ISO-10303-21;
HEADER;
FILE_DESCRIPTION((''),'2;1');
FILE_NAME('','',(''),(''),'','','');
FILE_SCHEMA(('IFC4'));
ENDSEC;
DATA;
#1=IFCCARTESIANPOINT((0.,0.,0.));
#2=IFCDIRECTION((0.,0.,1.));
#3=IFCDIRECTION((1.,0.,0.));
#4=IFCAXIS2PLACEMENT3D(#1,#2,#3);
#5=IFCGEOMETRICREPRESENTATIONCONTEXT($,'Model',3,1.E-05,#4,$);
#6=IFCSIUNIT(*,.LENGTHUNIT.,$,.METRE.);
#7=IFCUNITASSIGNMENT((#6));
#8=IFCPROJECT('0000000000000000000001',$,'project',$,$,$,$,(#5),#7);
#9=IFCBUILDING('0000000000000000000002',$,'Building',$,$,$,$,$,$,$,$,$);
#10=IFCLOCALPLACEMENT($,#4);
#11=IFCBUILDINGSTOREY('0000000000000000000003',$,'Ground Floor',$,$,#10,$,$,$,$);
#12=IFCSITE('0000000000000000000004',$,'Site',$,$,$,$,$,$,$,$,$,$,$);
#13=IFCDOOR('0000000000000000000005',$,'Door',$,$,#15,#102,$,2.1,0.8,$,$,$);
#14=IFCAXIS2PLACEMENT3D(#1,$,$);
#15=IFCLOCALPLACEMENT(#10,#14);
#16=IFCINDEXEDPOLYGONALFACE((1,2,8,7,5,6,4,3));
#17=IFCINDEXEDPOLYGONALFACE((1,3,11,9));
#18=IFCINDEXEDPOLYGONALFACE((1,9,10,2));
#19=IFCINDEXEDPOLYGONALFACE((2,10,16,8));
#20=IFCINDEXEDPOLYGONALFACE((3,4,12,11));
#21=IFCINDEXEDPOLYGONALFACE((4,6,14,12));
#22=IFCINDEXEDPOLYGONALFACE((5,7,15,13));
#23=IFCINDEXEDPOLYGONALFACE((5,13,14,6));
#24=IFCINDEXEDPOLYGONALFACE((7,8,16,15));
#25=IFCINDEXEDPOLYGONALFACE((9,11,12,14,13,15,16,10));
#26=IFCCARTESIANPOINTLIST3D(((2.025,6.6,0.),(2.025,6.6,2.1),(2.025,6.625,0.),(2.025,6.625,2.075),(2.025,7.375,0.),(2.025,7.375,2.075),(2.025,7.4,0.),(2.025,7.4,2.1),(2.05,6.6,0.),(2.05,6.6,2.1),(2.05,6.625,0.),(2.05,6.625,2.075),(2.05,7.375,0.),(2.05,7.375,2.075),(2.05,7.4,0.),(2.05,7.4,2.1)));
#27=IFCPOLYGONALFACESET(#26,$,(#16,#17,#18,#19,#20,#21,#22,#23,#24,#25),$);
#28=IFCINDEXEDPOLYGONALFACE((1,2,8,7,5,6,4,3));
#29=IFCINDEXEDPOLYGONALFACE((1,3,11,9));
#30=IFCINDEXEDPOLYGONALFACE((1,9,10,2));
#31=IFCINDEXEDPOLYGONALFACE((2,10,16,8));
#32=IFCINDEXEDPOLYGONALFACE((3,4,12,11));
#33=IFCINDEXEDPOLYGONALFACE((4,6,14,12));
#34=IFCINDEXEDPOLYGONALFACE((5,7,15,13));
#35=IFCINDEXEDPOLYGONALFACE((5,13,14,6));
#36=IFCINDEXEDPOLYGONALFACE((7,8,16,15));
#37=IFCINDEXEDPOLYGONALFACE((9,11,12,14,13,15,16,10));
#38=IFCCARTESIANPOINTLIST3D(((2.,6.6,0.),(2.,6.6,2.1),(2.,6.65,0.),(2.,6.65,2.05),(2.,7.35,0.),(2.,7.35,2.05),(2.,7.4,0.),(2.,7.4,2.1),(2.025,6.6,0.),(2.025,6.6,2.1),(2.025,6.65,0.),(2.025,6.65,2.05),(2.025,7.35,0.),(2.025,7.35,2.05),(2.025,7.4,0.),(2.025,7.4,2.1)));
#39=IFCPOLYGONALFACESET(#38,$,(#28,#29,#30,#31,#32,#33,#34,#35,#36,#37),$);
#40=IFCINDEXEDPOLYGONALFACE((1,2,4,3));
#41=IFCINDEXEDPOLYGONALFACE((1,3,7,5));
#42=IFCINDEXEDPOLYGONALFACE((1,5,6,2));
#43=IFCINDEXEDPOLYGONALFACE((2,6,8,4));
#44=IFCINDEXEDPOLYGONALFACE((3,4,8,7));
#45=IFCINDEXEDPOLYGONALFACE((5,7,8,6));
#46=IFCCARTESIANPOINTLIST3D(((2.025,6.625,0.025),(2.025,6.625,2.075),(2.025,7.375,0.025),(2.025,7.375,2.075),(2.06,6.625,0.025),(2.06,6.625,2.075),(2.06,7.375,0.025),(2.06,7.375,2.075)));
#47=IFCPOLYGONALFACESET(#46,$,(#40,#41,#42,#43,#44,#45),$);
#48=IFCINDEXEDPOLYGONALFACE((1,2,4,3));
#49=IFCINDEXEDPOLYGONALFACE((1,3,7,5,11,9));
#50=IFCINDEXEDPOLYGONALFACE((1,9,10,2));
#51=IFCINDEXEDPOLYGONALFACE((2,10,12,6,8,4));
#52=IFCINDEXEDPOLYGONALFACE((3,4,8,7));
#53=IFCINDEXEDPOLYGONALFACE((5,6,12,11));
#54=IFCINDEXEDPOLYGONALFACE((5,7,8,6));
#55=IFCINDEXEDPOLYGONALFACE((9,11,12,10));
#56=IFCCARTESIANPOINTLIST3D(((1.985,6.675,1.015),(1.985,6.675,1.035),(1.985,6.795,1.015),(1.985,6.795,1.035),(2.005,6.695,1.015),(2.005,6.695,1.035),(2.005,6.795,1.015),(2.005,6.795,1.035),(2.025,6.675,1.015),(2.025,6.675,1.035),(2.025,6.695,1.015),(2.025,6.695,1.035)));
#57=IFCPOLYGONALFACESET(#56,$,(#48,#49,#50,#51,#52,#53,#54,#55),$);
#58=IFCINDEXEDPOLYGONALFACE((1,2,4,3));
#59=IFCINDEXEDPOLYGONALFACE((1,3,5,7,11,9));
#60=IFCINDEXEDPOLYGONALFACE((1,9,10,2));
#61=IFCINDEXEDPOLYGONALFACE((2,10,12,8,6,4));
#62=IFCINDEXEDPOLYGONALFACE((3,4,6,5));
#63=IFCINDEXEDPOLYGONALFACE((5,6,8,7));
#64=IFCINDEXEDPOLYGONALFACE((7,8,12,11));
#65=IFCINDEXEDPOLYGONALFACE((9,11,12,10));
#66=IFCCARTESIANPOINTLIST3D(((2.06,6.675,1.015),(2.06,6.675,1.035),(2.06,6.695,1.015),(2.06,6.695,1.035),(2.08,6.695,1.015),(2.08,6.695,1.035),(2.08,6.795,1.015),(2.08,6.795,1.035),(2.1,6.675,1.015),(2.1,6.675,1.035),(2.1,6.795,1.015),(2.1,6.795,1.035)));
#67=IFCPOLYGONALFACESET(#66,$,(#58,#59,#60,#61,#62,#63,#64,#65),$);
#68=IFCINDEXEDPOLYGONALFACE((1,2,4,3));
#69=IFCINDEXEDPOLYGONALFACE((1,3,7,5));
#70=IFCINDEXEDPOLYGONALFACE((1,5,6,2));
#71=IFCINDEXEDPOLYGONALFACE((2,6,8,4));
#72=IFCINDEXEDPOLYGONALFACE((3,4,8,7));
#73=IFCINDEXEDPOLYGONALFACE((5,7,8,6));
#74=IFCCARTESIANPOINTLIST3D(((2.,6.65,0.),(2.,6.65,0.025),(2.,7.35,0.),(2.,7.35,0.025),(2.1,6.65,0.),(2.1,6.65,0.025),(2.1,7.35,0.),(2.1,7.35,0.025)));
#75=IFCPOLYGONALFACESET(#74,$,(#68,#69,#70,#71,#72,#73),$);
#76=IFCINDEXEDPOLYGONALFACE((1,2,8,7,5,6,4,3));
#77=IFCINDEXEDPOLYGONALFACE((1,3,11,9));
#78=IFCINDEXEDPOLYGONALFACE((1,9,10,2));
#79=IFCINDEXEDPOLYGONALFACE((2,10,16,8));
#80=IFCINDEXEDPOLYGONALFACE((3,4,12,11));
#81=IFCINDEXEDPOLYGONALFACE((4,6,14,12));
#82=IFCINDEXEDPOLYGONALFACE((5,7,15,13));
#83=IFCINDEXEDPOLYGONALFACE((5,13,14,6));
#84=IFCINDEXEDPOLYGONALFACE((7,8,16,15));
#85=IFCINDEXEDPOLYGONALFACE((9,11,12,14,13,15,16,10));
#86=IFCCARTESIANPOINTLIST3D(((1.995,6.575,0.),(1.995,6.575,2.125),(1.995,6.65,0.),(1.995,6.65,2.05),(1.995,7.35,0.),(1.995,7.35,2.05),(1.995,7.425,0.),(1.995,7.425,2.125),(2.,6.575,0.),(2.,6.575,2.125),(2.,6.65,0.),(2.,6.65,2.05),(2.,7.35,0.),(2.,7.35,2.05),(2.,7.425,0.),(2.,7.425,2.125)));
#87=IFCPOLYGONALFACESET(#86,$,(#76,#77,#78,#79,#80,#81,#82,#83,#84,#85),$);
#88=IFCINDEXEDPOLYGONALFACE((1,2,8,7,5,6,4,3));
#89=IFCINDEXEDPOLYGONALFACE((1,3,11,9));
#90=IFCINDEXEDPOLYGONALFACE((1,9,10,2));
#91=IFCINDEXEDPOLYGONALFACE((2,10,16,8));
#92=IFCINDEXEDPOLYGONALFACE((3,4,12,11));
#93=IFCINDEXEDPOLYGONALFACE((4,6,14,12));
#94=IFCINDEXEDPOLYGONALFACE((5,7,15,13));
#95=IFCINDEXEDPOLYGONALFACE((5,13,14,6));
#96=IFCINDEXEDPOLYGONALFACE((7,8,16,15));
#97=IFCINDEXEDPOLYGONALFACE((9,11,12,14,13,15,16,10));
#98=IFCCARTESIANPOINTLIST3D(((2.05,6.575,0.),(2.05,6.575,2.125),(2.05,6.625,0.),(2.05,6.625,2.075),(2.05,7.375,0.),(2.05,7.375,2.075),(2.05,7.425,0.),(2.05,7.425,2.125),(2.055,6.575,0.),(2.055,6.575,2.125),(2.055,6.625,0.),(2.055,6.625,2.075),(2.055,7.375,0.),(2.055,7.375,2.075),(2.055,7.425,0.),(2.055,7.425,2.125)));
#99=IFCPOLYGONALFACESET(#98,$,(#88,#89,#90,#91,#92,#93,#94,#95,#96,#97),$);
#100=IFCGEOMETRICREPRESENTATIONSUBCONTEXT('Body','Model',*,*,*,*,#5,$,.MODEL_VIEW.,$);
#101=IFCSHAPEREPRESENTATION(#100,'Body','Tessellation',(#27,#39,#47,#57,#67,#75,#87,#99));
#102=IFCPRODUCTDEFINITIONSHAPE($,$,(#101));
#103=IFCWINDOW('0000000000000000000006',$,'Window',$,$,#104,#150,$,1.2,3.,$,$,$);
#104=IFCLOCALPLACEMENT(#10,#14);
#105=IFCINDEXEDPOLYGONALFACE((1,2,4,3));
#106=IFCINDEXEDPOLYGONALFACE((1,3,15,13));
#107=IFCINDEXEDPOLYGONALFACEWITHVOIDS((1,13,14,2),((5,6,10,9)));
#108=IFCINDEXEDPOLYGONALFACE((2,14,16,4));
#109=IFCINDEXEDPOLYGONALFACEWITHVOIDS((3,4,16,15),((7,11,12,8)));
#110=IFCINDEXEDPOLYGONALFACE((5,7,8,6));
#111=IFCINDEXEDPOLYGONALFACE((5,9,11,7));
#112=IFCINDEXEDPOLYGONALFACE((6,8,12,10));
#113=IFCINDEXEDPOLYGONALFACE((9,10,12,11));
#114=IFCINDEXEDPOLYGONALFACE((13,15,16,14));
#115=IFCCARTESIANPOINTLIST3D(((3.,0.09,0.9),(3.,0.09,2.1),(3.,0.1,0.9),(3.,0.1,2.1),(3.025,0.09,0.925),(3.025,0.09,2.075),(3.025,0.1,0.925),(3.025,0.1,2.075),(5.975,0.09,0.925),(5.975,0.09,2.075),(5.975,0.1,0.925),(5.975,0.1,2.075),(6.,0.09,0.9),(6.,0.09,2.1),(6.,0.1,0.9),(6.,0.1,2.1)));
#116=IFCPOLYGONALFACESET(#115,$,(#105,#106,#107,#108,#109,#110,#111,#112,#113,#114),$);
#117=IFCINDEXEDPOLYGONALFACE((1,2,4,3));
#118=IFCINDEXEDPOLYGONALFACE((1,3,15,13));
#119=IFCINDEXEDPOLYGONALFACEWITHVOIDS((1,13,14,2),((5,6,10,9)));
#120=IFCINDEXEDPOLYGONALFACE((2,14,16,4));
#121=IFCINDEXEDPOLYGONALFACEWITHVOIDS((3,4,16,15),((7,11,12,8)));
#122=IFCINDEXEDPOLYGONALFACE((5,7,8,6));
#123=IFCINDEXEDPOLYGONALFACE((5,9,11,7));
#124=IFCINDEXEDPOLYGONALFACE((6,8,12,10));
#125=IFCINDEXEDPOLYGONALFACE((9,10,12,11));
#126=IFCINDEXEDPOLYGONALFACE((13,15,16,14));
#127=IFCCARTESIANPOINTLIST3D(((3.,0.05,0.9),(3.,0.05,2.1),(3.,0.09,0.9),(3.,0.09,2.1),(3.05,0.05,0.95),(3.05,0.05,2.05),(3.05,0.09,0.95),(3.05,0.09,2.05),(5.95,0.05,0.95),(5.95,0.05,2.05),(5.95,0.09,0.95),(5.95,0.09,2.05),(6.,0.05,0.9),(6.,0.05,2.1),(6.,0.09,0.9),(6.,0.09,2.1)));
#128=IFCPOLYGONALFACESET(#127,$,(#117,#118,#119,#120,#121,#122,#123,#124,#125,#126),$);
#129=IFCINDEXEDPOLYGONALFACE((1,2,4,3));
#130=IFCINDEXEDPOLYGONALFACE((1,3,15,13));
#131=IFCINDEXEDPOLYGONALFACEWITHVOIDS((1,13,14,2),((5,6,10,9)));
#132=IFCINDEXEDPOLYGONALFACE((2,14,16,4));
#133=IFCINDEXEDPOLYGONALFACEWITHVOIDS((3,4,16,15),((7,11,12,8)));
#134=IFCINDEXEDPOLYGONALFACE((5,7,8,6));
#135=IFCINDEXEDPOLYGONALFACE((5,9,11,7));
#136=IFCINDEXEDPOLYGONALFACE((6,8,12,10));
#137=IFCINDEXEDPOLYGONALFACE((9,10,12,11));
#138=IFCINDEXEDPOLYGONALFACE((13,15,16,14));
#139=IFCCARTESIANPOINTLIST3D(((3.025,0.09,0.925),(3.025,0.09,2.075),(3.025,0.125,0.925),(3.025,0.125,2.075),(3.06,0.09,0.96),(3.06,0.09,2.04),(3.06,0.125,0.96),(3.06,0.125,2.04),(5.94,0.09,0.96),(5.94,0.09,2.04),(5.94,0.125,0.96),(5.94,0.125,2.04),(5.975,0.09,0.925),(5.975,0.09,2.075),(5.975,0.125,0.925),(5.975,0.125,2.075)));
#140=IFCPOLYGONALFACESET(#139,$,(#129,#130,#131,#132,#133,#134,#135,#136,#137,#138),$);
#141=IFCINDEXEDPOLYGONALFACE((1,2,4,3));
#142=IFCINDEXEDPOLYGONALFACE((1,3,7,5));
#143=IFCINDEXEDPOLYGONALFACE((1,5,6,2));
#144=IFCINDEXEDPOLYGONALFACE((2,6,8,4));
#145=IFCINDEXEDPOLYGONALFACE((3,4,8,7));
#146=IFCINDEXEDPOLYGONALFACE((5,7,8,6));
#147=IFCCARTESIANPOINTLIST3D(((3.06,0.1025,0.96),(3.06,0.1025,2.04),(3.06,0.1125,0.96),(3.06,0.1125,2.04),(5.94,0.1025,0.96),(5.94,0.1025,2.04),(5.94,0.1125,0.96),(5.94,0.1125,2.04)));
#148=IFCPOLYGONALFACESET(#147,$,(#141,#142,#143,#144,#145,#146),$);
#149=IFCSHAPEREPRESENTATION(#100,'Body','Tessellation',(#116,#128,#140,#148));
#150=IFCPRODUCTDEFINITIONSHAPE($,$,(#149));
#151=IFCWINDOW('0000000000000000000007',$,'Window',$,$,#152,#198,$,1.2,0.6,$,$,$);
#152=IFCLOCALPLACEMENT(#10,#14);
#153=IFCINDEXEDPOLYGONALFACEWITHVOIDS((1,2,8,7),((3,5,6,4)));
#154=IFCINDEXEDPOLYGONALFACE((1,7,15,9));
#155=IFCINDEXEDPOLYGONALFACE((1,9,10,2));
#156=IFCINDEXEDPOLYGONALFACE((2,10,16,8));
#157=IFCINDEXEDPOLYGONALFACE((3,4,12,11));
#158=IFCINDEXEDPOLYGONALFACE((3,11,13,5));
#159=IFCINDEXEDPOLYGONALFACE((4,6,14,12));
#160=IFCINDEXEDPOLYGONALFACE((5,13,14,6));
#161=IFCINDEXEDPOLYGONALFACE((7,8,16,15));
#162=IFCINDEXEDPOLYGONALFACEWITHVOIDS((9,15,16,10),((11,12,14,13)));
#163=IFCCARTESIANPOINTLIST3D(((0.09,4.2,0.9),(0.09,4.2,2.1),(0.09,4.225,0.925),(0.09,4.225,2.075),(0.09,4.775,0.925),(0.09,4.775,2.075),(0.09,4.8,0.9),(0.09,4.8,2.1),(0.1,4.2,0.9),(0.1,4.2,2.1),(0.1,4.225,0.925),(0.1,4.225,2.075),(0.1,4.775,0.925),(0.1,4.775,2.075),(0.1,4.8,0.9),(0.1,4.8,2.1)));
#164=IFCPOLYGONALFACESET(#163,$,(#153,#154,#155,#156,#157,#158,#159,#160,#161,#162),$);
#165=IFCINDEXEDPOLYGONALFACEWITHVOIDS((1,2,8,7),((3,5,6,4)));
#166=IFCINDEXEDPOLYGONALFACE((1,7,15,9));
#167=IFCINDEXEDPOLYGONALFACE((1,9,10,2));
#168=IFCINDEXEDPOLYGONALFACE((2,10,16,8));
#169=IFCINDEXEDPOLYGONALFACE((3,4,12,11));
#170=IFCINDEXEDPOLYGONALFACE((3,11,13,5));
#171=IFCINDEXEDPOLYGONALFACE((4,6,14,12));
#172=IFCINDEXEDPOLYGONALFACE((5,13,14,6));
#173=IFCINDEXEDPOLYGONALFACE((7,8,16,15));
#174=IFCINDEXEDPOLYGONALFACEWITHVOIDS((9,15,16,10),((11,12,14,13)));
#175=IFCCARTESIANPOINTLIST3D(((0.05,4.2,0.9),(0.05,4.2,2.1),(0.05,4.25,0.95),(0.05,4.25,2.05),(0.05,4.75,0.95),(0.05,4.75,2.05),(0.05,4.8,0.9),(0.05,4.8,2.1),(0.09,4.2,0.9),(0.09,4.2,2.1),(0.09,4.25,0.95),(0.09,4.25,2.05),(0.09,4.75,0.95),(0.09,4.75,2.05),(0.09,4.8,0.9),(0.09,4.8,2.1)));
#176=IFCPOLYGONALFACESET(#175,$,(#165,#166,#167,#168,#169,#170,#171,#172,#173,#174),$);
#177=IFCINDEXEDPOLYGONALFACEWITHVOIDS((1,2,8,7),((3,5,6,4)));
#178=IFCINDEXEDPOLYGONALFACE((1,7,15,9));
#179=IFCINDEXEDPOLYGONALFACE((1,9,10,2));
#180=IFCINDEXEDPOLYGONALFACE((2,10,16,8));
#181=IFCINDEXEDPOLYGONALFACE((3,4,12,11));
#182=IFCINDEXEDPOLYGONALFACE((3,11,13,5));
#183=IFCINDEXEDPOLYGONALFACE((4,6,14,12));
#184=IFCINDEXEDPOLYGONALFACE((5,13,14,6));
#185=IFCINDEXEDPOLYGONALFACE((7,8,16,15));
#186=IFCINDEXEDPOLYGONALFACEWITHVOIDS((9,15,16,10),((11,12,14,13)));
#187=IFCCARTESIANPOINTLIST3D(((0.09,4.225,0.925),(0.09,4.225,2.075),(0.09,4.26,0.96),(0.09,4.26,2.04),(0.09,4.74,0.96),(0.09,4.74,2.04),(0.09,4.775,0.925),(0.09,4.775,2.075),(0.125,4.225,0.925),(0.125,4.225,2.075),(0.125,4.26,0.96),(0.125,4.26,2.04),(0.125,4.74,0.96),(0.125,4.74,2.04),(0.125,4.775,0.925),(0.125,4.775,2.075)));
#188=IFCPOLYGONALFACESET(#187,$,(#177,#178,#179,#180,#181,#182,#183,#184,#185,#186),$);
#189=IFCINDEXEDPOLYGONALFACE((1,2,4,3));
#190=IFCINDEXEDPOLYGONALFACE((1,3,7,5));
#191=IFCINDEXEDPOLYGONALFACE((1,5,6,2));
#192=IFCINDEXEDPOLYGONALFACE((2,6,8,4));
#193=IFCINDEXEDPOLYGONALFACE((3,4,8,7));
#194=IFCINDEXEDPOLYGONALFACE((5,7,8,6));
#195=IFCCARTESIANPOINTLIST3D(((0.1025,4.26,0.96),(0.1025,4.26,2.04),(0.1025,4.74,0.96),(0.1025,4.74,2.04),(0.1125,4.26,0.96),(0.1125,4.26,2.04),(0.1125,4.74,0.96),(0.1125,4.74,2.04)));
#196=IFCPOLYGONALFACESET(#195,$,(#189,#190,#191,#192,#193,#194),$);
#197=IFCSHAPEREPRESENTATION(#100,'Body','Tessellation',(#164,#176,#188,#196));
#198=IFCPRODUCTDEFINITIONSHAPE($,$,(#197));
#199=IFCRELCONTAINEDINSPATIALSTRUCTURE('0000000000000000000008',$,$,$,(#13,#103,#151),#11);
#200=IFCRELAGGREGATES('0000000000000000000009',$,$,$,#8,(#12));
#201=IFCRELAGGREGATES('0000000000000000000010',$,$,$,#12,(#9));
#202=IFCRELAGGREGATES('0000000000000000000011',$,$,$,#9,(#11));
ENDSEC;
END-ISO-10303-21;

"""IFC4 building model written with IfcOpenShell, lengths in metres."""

from ifc_helpers import new_model, si_unit, frame, origin_with_axes, place, context, subcontext, project, spatial, line, indexed_curve, outline, extrude, element, save


model = new_model("IFC4")

# Units and contexts
model_context = context("Model", 3, precision=1e-05, world=origin_with_axes())
body_context = subcontext(model_context, "Body", "Model", "MODEL_VIEW")
ifc_project = project(units=[si_unit("LENGTHUNIT", "METRE")], contexts=[model_context])

# Site, building, storey
site = spatial("IfcSite", under=ifc_project, Name="Site")
building = spatial("IfcBuilding", under=site, Name="Building")
storey_placement = place(None, origin_with_axes())
storey = spatial("IfcBuildingStorey", under=building, at=storey_placement, Name="Ground Floor")

# Door
door_1_placement = place(storey_placement, frame((2.0, 7.4, 0.0), z_axis=(0.0, 0.0, 1.0), x_axis=(0.0, -1.0, 0.0)))
element("IfcDoor", 1, at=door_1_placement, inside=storey, Name="Door", OverallHeight=2.1, OverallWidth=0.8, context=body_context, shape_type="SweptSolid", body=[
    extrude(outline(indexed_curve([(0.0, 0.0), (0.0, 2.1), (0.8, 2.1), (0.8, 0.0), (0.775, 0.0), (0.775, 2.075), (0.025, 2.075), (0.025, 0.0)], segments=[line(1, 2, 3, 4, 5, 6, 7, 8, 1)])), frame((0.0, 0.025, 0.0), z_axis=(0.0, -1.0, 0.0), x_axis=(1.0, 0.0, 0.0)), (0.0, 0.0, -1.0), 0.025),
    extrude(outline(indexed_curve([(0.0, 0.0), (0.0, 2.1), (0.8, 2.1), (0.8, 0.0), (0.75, 0.0), (0.75, 2.05), (0.05, 2.05), (0.05, 0.0)], segments=[line(1, 2, 3, 4, 5, 6, 7, 8, 1)])), frame((0.0, 0.0, 0.0), z_axis=(0.0, -1.0, 0.0), x_axis=(1.0, 0.0, 0.0)), (0.0, 0.0, -1.0), 0.025),
    extrude(outline(indexed_curve([(0.0, 0.0), (0.75, 0.0), (0.75, 0.035), (0.0, 0.035)], segments=[line(1, 2, 3, 4, 1)])), frame((0.025, 0.025, 0.025), z_axis=(0.0, 0.0, 1.0), x_axis=(1.0, 0.0, 0.0)), (0.0, 0.0, 1.0), 2.05),
    extrude(outline(indexed_curve([(0.0, 0.0), (0.0, -0.04), (-0.12, -0.04), (-0.12, -0.02), (-0.02, -0.02), (-0.02, 0.0)], segments=[line(1, 2, 3, 4, 5, 6, 1)])), frame((0.725, 0.025, 1.015), z_axis=(0.0, 0.0, 1.0), x_axis=(1.0, 0.0, 0.0)), (0.0, 0.0, 1.0), 0.02),
    extrude(outline(indexed_curve([(0.0, 0.0), (0.0, 0.04), (-0.12, 0.04), (-0.12, 0.02), (-0.02, 0.02), (-0.02, 0.0)], segments=[line(1, 2, 3, 4, 5, 6, 1)])), frame((0.725, 0.06, 1.015), z_axis=(0.0, 0.0, 1.0), x_axis=(1.0, 0.0, 0.0)), (0.0, 0.0, 1.0), 0.02),
    extrude(outline(indexed_curve([(0.0, 0.0), (0.7, 0.0), (0.7, 0.1), (0.0, 0.1)], segments=[line(1, 2, 3, 4, 1)])), frame((0.05, 0.0, 0.0), z_axis=(0.0, 0.0, 1.0), x_axis=(1.0, 0.0, 0.0)), (0.0, 0.0, 1.0), 0.025),
    extrude(outline(indexed_curve([(0.0, 0.0), (0.0, 2.125), (0.85, 2.125), (0.85, 0.0), (0.775, 0.0), (0.775, 2.05), (0.075, 2.05), (0.075, 0.0)], segments=[line(1, 2, 3, 4, 5, 6, 7, 8, 1)])), frame((-0.025, -0.005, 0.0), z_axis=(0.0, -1.0, 0.0), x_axis=(1.0, 0.0, 0.0)), (0.0, 0.0, -1.0), 0.005),
    extrude(outline(indexed_curve([(0.0, 0.0), (0.0, 2.125), (0.85, 2.125), (0.85, 0.0), (0.8, 0.0), (0.8, 2.075), (0.05, 2.075), (0.05, 0.0)], segments=[line(1, 2, 3, 4, 5, 6, 7, 8, 1)])), frame((-0.025, 0.05, 0.0), z_axis=(0.0, -1.0, 0.0), x_axis=(1.0, 0.0, 0.0)), (0.0, 0.0, -1.0), 0.005),
])

# Windows
window_1_placement = place(storey_placement, frame((3.0, 0.0, 0.9), z_axis=(0.0, 0.0, 1.0), x_axis=(1.0, 0.0, 0.0)))
element("IfcWindow", 2, at=window_1_placement, inside=storey, Name="Window", OverallHeight=1.2, OverallWidth=3.0, context=body_context, shape_type="SweptSolid", body=[
    extrude(outline(indexed_curve([(0.0, 0.0), (3.0, 0.0), (3.0, 1.2), (0.0, 1.2)], segments=[line(1, 2, 3, 4, 1)]), holes=[indexed_curve([(0.025, 0.025), (2.975, 0.025), (2.975, 1.175), (0.025, 1.175)], segments=[line(1, 2, 3, 4, 1)])]), frame((0.0, 0.09, 0.0), z_axis=(0.0, -1.0, 0.0), x_axis=(1.0, 0.0, 0.0)), (0.0, 0.0, -1.0), 0.01),
    extrude(outline(indexed_curve([(0.0, 0.0), (3.0, 0.0), (3.0, 1.2), (0.0, 1.2)], segments=[line(1, 2, 3, 4, 1)]), holes=[indexed_curve([(0.05, 0.05), (2.95, 0.05), (2.95, 1.15), (0.05, 1.15)], segments=[line(1, 2, 3, 4, 1)])]), frame((0.0, 0.05, 0.0), z_axis=(0.0, -1.0, 0.0), x_axis=(1.0, 0.0, 0.0)), (0.0, 0.0, -1.0), 0.04),
    extrude(outline(indexed_curve([(0.0, 0.0), (2.95, 0.0), (2.95, 1.15), (0.0, 1.15)], segments=[line(1, 2, 3, 4, 1)]), holes=[indexed_curve([(0.035, 0.035), (2.915, 0.035), (2.915, 1.115), (0.035, 1.115)], segments=[line(1, 2, 3, 4, 1)])]), frame((0.025, 0.09, 0.025), z_axis=(0.0, -1.0, 0.0), x_axis=(1.0, 0.0, 0.0)), (0.0, 0.0, -1.0), 0.035),
    extrude(outline(indexed_curve([(0.035, 0.035), (2.915, 0.035), (2.915, 1.115), (0.035, 1.115)], segments=[line(1, 2, 3, 4, 1)])), frame((0.025, 0.1025, 0.025), z_axis=(0.0, -1.0, 0.0), x_axis=(1.0, 0.0, 0.0)), (0.0, 0.0, -1.0), 0.01),
])
window_2_placement = place(storey_placement, frame((0.0, 4.8, 0.9), z_axis=(0.0, 0.0, 1.0), x_axis=(0.0, -1.0, 0.0)))
element("IfcWindow", 3, at=window_2_placement, inside=storey, Name="Window", OverallHeight=1.2, OverallWidth=0.6, context=body_context, shape_type="SweptSolid", body=[
    extrude(outline(indexed_curve([(0.0, 0.0), (0.6, 0.0), (0.6, 1.2), (0.0, 1.2)], segments=[line(1, 2, 3, 4, 1)]), holes=[indexed_curve([(0.025, 0.025), (0.575, 0.025), (0.575, 1.175), (0.025, 1.175)], segments=[line(1, 2, 3, 4, 1)])]), frame((0.0, 0.09, 0.0), z_axis=(0.0, -1.0, 0.0), x_axis=(1.0, 0.0, 0.0)), (0.0, 0.0, -1.0), 0.01),
    extrude(outline(indexed_curve([(0.0, 0.0), (0.6, 0.0), (0.6, 1.2), (0.0, 1.2)], segments=[line(1, 2, 3, 4, 1)]), holes=[indexed_curve([(0.05, 0.05), (0.55, 0.05), (0.55, 1.15), (0.05, 1.15)], segments=[line(1, 2, 3, 4, 1)])]), frame((0.0, 0.05, 0.0), z_axis=(0.0, -1.0, 0.0), x_axis=(1.0, 0.0, 0.0)), (0.0, 0.0, -1.0), 0.04),
    extrude(outline(indexed_curve([(0.0, 0.0), (0.55, 0.0), (0.55, 1.15), (0.0, 1.15)], segments=[line(1, 2, 3, 4, 1)]), holes=[indexed_curve([(0.035, 0.035), (0.515, 0.035), (0.515, 1.115), (0.035, 1.115)], segments=[line(1, 2, 3, 4, 1)])]), frame((0.025, 0.09, 0.025), z_axis=(0.0, -1.0, 0.0), x_axis=(1.0, 0.0, 0.0)), (0.0, 0.0, -1.0), 0.035),
    extrude(outline(indexed_curve([(0.035, 0.035), (0.515, 0.035), (0.515, 1.115), (0.035, 1.115)], segments=[line(1, 2, 3, 4, 1)])), frame((0.025, 0.1025, 0.025), z_axis=(0.0, -1.0, 0.0), x_axis=(1.0, 0.0, 0.0)), (0.0, 0.0, -1.0), 0.01),
])

save(model, "model.ifc")
